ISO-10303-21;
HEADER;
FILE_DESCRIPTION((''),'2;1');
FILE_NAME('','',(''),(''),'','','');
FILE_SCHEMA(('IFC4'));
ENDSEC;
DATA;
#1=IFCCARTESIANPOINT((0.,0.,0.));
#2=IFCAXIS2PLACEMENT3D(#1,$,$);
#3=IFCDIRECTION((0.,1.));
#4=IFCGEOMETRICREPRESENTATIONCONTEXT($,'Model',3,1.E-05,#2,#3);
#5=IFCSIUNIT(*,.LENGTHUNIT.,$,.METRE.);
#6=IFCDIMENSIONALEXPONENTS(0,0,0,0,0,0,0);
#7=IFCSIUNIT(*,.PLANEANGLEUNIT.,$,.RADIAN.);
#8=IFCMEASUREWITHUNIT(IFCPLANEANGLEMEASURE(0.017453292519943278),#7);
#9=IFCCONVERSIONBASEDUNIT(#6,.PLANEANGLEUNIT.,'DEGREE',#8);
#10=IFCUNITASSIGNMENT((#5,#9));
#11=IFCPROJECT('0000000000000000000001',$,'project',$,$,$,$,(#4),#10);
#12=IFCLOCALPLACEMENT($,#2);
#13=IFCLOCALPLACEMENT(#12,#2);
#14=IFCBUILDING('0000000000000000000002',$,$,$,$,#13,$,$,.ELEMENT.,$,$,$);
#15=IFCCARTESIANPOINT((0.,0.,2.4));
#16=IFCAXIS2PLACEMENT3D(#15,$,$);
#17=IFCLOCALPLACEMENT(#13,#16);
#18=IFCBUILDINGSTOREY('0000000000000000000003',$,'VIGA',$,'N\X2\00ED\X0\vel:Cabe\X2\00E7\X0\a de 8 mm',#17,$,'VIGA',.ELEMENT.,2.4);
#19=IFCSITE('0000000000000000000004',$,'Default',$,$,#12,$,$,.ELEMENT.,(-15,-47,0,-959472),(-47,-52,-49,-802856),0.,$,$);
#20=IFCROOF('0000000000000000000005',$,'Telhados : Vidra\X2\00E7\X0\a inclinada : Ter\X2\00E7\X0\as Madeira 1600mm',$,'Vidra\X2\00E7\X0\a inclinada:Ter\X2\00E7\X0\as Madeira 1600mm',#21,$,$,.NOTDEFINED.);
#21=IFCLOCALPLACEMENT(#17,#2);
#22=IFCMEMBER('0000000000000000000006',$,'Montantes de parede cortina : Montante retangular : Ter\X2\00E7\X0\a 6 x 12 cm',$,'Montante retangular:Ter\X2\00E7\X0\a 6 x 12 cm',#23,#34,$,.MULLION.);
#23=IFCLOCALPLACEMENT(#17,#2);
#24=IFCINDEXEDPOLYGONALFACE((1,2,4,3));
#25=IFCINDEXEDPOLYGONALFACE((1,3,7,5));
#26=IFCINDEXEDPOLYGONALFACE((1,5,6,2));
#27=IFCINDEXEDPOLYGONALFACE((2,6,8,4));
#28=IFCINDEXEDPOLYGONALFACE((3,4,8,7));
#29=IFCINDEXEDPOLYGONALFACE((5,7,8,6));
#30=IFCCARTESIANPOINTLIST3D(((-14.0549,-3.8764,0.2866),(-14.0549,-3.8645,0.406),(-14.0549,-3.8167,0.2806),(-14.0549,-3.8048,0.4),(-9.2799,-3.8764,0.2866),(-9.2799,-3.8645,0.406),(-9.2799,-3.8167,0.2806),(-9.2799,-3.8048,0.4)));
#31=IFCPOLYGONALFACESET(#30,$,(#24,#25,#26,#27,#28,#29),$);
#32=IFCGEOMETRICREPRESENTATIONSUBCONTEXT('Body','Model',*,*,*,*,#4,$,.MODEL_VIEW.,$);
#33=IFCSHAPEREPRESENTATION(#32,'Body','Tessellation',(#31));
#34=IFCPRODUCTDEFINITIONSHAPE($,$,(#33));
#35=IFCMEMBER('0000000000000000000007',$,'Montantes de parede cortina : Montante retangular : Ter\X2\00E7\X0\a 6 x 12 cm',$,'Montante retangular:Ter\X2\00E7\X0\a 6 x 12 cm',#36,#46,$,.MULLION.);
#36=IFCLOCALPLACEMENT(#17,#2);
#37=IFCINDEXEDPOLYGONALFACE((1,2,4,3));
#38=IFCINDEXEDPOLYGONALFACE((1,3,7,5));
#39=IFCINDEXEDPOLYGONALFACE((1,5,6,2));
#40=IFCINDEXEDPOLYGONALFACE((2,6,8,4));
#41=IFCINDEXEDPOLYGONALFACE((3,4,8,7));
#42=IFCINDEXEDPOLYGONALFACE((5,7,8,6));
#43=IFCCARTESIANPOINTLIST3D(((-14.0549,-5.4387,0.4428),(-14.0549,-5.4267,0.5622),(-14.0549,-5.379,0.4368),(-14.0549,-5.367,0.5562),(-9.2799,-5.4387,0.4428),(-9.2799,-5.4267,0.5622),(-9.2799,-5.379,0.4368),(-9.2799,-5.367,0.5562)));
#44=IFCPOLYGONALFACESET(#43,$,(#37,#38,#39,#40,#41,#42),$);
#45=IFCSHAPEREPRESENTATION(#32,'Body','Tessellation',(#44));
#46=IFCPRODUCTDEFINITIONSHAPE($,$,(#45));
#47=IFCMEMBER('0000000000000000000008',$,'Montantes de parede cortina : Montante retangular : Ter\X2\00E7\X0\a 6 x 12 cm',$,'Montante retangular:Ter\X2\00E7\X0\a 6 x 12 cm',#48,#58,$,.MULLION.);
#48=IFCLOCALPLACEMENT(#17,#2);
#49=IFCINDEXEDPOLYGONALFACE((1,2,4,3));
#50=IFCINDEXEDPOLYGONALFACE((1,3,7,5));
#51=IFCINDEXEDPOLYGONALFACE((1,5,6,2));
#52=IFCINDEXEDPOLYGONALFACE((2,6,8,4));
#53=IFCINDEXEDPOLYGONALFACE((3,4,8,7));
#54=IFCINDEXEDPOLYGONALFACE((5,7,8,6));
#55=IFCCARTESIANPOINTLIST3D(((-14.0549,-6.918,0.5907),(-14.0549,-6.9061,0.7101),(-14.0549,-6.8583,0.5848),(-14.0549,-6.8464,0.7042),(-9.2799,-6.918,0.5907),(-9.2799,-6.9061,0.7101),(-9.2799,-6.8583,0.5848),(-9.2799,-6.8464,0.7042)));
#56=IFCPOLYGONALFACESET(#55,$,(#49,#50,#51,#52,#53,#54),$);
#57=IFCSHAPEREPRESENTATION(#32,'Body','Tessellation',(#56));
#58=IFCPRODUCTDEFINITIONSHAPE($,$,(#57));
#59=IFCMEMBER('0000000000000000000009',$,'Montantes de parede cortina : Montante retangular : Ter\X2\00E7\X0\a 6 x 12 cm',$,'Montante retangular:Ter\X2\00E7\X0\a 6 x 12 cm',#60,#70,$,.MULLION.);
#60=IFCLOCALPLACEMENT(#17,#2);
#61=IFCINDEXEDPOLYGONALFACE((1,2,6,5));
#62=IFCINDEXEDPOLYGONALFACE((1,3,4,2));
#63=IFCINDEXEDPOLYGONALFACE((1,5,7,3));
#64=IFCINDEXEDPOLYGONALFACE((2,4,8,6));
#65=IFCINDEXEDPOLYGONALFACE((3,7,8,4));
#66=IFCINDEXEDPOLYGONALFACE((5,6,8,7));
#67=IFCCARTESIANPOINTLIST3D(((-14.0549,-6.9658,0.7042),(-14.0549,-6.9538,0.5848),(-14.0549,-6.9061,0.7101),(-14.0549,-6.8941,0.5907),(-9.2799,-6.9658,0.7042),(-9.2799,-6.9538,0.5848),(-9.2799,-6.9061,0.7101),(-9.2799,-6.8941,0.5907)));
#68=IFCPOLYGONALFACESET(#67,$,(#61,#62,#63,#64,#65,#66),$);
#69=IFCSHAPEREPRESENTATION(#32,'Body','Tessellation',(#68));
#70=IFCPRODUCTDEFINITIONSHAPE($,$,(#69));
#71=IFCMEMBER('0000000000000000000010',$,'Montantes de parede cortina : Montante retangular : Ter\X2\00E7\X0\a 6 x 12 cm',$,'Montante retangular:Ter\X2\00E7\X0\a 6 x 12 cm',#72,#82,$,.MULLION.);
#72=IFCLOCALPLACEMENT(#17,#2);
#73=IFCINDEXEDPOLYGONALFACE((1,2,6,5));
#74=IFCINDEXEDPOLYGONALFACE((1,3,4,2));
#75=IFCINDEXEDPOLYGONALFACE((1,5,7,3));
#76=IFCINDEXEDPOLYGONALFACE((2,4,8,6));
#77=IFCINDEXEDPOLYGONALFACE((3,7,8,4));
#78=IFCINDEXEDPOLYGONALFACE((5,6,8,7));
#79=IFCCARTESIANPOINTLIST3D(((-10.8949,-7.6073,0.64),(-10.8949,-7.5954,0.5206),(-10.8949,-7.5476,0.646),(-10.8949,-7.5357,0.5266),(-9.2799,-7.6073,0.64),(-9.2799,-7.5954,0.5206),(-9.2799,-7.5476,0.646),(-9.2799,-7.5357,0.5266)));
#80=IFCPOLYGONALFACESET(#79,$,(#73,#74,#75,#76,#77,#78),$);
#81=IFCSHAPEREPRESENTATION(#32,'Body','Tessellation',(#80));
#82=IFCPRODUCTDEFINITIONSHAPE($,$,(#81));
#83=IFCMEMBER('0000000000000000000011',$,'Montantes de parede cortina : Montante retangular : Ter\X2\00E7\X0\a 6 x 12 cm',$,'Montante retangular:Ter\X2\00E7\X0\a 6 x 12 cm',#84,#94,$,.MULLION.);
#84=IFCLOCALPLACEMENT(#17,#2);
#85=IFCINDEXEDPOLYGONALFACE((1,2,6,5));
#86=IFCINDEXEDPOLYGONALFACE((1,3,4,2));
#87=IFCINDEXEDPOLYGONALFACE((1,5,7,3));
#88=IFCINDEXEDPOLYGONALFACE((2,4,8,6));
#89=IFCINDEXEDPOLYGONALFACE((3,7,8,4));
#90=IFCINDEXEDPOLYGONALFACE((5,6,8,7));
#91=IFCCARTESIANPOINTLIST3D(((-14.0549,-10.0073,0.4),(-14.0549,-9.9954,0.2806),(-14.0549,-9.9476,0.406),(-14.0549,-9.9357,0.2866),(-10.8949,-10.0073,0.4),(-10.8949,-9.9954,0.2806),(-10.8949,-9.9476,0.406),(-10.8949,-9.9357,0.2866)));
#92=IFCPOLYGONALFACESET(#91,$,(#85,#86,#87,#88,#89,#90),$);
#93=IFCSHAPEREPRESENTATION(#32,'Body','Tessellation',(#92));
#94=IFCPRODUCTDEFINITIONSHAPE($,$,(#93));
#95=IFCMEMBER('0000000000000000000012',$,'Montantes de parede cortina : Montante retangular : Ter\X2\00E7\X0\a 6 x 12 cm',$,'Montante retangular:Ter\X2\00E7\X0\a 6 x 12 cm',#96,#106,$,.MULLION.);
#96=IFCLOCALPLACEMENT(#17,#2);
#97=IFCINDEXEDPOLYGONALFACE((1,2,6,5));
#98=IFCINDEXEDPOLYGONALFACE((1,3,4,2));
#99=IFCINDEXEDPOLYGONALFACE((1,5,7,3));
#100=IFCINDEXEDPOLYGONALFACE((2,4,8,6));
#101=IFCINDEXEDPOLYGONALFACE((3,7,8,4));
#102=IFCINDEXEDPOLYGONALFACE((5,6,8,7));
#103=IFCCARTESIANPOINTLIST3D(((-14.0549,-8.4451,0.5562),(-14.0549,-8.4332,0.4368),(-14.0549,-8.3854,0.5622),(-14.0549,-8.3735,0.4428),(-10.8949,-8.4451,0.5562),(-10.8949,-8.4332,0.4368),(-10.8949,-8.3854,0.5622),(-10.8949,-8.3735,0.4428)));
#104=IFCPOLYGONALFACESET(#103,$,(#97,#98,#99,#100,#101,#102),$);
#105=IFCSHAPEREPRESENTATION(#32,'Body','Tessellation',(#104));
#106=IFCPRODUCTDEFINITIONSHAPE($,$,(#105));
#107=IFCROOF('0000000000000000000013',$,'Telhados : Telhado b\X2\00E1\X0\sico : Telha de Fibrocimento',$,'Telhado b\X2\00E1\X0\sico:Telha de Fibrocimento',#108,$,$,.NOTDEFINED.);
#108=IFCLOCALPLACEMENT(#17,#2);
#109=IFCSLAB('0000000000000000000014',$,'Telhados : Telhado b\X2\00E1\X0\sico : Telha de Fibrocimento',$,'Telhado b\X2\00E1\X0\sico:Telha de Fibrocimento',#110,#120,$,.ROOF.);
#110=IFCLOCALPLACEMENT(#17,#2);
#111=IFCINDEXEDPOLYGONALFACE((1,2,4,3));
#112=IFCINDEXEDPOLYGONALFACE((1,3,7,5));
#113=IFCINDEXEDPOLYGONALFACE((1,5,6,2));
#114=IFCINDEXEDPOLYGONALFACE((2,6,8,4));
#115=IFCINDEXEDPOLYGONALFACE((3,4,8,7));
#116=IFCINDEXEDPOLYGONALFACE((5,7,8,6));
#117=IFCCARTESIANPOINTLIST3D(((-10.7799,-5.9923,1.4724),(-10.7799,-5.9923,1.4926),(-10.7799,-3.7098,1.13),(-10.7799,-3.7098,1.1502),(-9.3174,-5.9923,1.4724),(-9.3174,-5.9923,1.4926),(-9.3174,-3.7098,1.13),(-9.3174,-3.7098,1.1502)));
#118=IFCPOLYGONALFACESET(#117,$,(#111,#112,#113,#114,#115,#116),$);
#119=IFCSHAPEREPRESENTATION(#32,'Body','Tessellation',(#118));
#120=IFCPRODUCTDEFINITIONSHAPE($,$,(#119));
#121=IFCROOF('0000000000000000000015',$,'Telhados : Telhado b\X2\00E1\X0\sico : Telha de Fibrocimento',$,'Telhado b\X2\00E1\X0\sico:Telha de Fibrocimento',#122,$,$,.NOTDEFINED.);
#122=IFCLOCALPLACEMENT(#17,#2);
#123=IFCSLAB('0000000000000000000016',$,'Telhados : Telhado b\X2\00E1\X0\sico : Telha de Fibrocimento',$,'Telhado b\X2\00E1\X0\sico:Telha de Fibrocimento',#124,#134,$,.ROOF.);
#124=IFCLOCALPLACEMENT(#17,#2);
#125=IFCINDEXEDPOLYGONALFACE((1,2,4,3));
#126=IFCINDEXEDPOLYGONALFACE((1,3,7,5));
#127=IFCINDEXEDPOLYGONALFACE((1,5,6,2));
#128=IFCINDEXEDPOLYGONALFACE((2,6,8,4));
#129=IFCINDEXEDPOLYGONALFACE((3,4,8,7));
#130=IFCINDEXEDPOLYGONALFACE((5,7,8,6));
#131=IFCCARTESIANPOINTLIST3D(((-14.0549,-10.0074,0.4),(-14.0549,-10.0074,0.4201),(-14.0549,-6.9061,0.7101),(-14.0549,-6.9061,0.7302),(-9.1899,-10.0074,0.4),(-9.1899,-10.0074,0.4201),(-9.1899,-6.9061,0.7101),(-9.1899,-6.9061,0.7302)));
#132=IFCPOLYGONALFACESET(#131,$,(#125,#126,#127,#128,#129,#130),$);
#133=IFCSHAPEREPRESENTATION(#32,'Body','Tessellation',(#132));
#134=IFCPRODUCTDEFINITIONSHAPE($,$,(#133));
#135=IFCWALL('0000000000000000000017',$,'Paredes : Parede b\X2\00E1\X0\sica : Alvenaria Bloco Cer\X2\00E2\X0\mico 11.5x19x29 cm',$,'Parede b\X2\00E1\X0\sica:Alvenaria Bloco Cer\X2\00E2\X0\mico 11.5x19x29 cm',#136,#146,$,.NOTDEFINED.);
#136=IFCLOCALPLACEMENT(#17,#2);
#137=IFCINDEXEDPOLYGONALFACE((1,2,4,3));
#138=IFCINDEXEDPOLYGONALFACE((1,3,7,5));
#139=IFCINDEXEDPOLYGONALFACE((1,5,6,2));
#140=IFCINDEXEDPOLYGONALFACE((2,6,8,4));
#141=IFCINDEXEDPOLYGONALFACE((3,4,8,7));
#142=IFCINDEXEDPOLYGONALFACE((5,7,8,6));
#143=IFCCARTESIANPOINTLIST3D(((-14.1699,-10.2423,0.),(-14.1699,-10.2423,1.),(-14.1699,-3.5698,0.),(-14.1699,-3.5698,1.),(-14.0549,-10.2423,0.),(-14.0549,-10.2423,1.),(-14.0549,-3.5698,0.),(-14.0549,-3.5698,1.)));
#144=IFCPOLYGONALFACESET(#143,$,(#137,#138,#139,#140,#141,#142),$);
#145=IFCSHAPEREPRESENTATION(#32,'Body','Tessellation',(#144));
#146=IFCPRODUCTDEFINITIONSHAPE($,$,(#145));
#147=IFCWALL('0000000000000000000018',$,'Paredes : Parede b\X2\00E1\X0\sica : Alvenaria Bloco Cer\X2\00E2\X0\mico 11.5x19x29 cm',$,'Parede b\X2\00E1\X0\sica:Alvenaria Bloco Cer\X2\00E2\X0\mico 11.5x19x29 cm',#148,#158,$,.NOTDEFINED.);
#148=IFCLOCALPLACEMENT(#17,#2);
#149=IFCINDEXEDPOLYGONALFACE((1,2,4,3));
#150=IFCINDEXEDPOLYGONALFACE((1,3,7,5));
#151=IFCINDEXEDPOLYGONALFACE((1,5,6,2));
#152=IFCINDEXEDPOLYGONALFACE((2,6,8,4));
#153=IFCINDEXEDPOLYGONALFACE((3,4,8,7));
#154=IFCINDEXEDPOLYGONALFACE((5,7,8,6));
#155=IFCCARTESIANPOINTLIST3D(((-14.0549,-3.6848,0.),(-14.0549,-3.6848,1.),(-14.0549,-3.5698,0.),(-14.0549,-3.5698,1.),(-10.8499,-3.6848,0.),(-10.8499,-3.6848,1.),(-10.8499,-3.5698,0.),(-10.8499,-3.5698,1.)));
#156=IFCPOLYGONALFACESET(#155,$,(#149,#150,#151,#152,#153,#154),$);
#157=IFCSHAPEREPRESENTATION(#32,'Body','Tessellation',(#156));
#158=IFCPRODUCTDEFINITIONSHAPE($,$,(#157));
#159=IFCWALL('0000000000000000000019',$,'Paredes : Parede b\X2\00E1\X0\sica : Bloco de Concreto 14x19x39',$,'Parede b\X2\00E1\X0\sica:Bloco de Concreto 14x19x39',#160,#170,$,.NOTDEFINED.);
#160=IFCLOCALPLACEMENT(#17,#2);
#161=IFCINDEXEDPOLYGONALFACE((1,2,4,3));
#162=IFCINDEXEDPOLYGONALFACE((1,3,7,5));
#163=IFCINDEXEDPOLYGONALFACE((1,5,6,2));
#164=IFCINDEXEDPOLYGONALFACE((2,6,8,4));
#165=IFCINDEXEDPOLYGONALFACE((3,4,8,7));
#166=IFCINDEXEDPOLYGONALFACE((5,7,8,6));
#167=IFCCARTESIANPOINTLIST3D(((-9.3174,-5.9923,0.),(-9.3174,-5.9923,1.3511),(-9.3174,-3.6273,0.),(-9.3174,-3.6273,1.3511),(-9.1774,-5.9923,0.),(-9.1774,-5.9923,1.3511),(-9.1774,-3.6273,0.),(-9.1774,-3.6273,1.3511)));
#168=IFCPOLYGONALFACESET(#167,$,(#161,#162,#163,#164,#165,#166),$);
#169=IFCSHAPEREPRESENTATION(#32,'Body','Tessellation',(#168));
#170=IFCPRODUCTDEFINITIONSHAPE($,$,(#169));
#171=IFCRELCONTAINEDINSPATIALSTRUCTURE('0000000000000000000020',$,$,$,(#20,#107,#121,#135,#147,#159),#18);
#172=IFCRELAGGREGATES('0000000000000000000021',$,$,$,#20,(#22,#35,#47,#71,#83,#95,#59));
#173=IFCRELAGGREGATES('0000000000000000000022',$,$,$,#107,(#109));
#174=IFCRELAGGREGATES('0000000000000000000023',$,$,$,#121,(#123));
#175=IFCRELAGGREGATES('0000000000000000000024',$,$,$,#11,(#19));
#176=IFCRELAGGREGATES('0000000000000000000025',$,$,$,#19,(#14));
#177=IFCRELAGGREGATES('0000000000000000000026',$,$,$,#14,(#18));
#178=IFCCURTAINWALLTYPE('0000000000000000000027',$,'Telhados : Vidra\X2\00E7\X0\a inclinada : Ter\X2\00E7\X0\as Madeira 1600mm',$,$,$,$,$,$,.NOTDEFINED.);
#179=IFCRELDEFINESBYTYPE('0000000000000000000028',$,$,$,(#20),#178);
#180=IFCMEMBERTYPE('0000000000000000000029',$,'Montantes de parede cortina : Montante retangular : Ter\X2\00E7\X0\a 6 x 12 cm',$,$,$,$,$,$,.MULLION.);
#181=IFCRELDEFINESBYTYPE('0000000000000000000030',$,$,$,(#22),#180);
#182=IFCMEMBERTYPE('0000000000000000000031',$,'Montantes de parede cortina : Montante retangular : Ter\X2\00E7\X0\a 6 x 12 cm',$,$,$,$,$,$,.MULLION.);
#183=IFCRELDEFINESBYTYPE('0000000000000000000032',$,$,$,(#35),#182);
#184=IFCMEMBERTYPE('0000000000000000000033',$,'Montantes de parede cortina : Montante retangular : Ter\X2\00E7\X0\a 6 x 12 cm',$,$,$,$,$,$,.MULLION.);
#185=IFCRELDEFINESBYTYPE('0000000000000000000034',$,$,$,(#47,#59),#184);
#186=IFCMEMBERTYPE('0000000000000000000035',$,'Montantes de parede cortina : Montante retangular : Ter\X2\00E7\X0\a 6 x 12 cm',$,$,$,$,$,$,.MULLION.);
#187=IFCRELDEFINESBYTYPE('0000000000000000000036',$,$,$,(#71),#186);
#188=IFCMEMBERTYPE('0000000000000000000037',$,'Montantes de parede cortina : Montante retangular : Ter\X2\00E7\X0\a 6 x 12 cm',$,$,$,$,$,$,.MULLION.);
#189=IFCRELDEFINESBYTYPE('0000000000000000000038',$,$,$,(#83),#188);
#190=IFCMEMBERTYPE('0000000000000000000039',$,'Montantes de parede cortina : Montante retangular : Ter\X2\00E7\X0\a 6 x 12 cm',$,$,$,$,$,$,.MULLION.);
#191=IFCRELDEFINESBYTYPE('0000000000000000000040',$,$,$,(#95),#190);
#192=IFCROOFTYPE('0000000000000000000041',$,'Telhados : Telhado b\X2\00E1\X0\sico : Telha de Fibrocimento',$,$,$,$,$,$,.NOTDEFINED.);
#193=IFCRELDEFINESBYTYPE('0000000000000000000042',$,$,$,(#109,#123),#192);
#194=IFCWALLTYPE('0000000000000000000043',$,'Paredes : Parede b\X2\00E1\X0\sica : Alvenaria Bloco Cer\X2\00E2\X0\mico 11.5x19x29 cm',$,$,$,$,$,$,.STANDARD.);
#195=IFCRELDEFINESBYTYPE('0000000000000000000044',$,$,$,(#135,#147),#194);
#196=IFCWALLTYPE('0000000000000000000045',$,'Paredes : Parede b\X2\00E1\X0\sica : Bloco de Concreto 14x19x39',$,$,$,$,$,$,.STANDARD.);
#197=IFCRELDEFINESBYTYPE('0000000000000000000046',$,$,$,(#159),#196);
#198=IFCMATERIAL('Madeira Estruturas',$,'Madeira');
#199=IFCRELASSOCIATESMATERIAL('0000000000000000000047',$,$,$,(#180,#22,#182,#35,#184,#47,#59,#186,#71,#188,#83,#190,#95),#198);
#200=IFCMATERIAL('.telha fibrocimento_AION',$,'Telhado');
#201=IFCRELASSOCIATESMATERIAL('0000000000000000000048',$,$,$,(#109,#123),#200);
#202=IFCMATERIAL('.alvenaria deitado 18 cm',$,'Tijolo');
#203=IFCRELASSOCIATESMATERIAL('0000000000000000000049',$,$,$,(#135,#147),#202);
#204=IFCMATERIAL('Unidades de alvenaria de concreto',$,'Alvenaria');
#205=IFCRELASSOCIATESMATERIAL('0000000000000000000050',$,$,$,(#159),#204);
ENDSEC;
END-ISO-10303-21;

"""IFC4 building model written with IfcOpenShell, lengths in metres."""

from ifc_helpers import new_model, entity, si_unit, converted_unit, direction, frame, origin, place, context, subcontext, project, spatial, indexed_curve, outline, extrude, source, transform, mapped, material, type_object, type_shapes, element, aggregate, save


model = new_model("IFC4")

# Units and contexts
model_context = context("Model", 3, precision=1e-05, world=origin(), true_north=direction((0.0, 1.0)))
body_context = subcontext(model_context, "Body", "Model", "MODEL_VIEW")
ifc_project = project(units=[si_unit("LENGTHUNIT", "METRE"), converted_unit("PLANEANGLEUNIT", "DEGREE", entity("IfcPlaneAngleMeasure", 0.017453292519943278), si_unit("PLANEANGLEUNIT", "RADIAN"), dimensions=[0, 0, 0, 0, 0, 0, 0])], contexts=[model_context])

# Site, building, storey
site_placement = place(None, origin())
site = spatial("IfcSite", under=ifc_project, at=site_placement, Name="Default", CompositionType="ELEMENT", RefLatitude=(-15, -47, 0, -959472), RefLongitude=(-47, -52, -49, -802856), RefElevation=0.0)
building_placement = place(site_placement, origin())
building = spatial("IfcBuilding", under=site, at=building_placement, CompositionType="ELEMENT")
storey_placement = place(building_placement, frame((0.0, 0.0, 2.4)))
storey = spatial("IfcBuildingStorey", under=building, at=storey_placement, Name="VIGA", ObjectType="Nível:Cabeça de 8 mm", LongName="VIGA", CompositionType="ELEMENT", Elevation=2.4)

# Roof, members
curtain_wall_type = type_object("IfcCurtainWallType", Name="Telhados : Vidraça inclinada : Terças Madeira 1600mm", PredefinedType="NOTDEFINED")
roof_1_placement = place(storey_placement, frame((0.0, 0.0, -2.4)))
roof_1 = element("IfcRoof", 1, at=roof_1_placement, inside=storey, type_object=curtain_wall_type, Name="Telhados : Vidraça inclinada : Terças Madeira 1600mm", ObjectType="Vidraça inclinada:Terças Madeira 1600mm", PredefinedType="NOTDEFINED")
ifc_material_1 = material(Name="Madeira Estruturas", Category="Madeira")
member_type_1 = type_object("IfcMemberType", Name="Montantes de parede cortina : Montante retangular : Terça 6 x 12 cm", PredefinedType="MULLION", material=ifc_material_1)
shared_shape_1 = source(origin(), body_context, "Body", "SweptSolid", [
    extrude(outline(indexed_curve([(-0.03, -0.06), (0.03, -0.06), (0.03, 0.06), (-0.03, 0.06), (-0.03, -0.06)], self_intersect=False)), frame((-0.03, 0.06, -4.775), z_axis=(0.0, 0.0, 1.0), x_axis=(-1.0, 0.0, 0.0)), (0.0, 0.0, 1.0), 4.775),
])
type_shapes(member_type_1, [shared_shape_1])
member_1_placement = place(roof_1_placement, frame((-14.0549, -3.8048, 2.8), z_axis=(-1.0, 0.0, 0.0), x_axis=(0.0, 0.995037, -0.099504)))
member_1 = element("IfcMember", 2, at=member_1_placement, type_object=member_type_1, material=ifc_material_1, Name="Montantes de parede cortina : Montante retangular : Terça 6 x 12 cm", ObjectType="Montante retangular:Terça 6 x 12 cm", PredefinedType="MULLION", context=body_context, shape_type="MappedRepresentation", body=[
    mapped(shared_shape_1, transform((0.0, 0.0, 0.0), scale=1.0)),
])
member_type_2 = type_object("IfcMemberType", Name="Montantes de parede cortina : Montante retangular : Terça 6 x 12 cm", PredefinedType="MULLION", material=ifc_material_1)
shared_shape_2 = source(origin(), body_context, "Body", "SweptSolid", [
    extrude(outline(indexed_curve([(-0.03, -0.06), (0.03, -0.06), (0.03, 0.06), (-0.03, 0.06), (-0.03, -0.06)], self_intersect=False)), frame((0.0, 0.06, -4.775), z_axis=(0.0, 0.0, 1.0), x_axis=(-1.0, 0.0, 0.0)), (0.0, 0.0, 1.0), 4.775),
])
type_shapes(member_type_2, [shared_shape_2])
member_2_placement = place(roof_1_placement, frame((-9.2799, -5.3969, 2.9592), z_axis=(1.0, 0.0, 0.0), x_axis=(0.0, -0.995037, 0.099504)))
member_2 = element("IfcMember", 3, at=member_2_placement, type_object=member_type_2, material=ifc_material_1, Name="Montantes de parede cortina : Montante retangular : Terça 6 x 12 cm", ObjectType="Montante retangular:Terça 6 x 12 cm", PredefinedType="MULLION", context=body_context, shape_type="MappedRepresentation", body=[
    mapped(shared_shape_2, transform((0.0, 0.0, 0.0), scale=1.0)),
])
member_type_3 = type_object("IfcMemberType", Name="Montantes de parede cortina : Montante retangular : Terça 6 x 12 cm", PredefinedType="MULLION", material=ifc_material_1)
shared_shape_3 = source(origin(), body_context, "Body", "SweptSolid", [
    extrude(outline(indexed_curve([(-0.03, -0.06), (0.03, -0.06), (0.03, 0.06), (-0.03, 0.06), (-0.03, -0.06)], self_intersect=False)), frame((-0.03, 0.06, -4.775), z_axis=(0.0, 0.0, 1.0), x_axis=(-1.0, 0.0, 0.0)), (0.0, 0.0, 1.0), 4.775),
])
type_shapes(member_type_3, [shared_shape_3])
member_3_placement = place(roof_1_placement, frame((-9.2799, -6.9061, 3.1101), z_axis=(1.0, 0.0, 0.0), x_axis=(0.0, -0.995037, 0.099504)))
member_3 = element("IfcMember", 4, at=member_3_placement, type_object=member_type_3, material=ifc_material_1, Name="Montantes de parede cortina : Montante retangular : Terça 6 x 12 cm", ObjectType="Montante retangular:Terça 6 x 12 cm", PredefinedType="MULLION", context=body_context, shape_type="MappedRepresentation", body=[
    mapped(shared_shape_3, transform((0.0, 0.0, 0.0), scale=1.0)),
])
member_4_placement = place(roof_1_placement, frame((-14.0549, -6.9061, 3.1101), z_axis=(-1.0, 0.0, 0.0), x_axis=(0.0, 0.995037, 0.099504)))
member_4 = element("IfcMember", 5, at=member_4_placement, type_object=member_type_3, material=ifc_material_1, Name="Montantes de parede cortina : Montante retangular : Terça 6 x 12 cm", ObjectType="Montante retangular:Terça 6 x 12 cm", PredefinedType="MULLION", context=body_context, shape_type="MappedRepresentation", body=[
    mapped(shared_shape_3, transform((0.0, 0.0, 0.0), scale=1.0)),
])
member_type_4 = type_object("IfcMemberType", Name="Montantes de parede cortina : Montante retangular : Terça 6 x 12 cm", PredefinedType="MULLION", material=ifc_material_1)
shared_shape_4 = source(origin(), body_context, "Body", "SweptSolid", [
    extrude(outline(indexed_curve([(-0.03, -0.06), (0.03, -0.06), (0.03, 0.06), (-0.03, 0.06), (-0.03, -0.06)], self_intersect=False)), frame((-0.03, 0.06, -1.615), z_axis=(0.0, 0.0, 1.0), x_axis=(-1.0, 0.0, 0.0)), (0.0, 0.0, 1.0), 1.615),
])
type_shapes(member_type_4, [shared_shape_4])
member_5_placement = place(roof_1_placement, frame((-9.2799, -7.6073, 3.04), z_axis=(1.0, 0.0, 0.0), x_axis=(0.0, -0.995037, -0.099504)))
member_5 = element("IfcMember", 6, at=member_5_placement, type_object=member_type_4, material=ifc_material_1, Name="Montantes de parede cortina : Montante retangular : Terça 6 x 12 cm", ObjectType="Montante retangular:Terça 6 x 12 cm", PredefinedType="MULLION", context=body_context, shape_type="MappedRepresentation", body=[
    mapped(shared_shape_4, transform((0.0, 0.0, 0.0), scale=1.0)),
])
member_type_5 = type_object("IfcMemberType", Name="Montantes de parede cortina : Montante retangular : Terça 6 x 12 cm", PredefinedType="MULLION", material=ifc_material_1)
shared_shape_5 = source(origin(), body_context, "Body", "SweptSolid", [
    extrude(outline(indexed_curve([(-0.03, -0.06), (0.03, -0.06), (0.03, 0.06), (-0.03, 0.06), (-0.03, -0.06)], self_intersect=False)), frame((-0.03, 0.06, -3.16), z_axis=(0.0, 0.0, 1.0), x_axis=(-1.0, 0.0, 0.0)), (0.0, 0.0, 1.0), 3.16),
])
type_shapes(member_type_5, [shared_shape_5])
member_6_placement = place(roof_1_placement, frame((-10.8949, -10.0073, 2.8), z_axis=(1.0, 0.0, 0.0), x_axis=(0.0, -0.995037, -0.099504)))
member_6 = element("IfcMember", 7, at=member_6_placement, type_object=member_type_5, material=ifc_material_1, Name="Montantes de parede cortina : Montante retangular : Terça 6 x 12 cm", ObjectType="Montante retangular:Terça 6 x 12 cm", PredefinedType="MULLION", context=body_context, shape_type="MappedRepresentation", body=[
    mapped(shared_shape_5, transform((0.0, 0.0, 0.0), scale=1.0)),
])
member_type_6 = type_object("IfcMemberType", Name="Montantes de parede cortina : Montante retangular : Terça 6 x 12 cm", PredefinedType="MULLION", material=ifc_material_1)
shared_shape_6 = source(origin(), body_context, "Body", "SweptSolid", [
    extrude(outline(indexed_curve([(-0.03, -0.06), (0.03, -0.06), (0.03, 0.06), (-0.03, 0.06), (-0.03, -0.06)], self_intersect=False)), frame((0.0, 0.06, -3.16), z_axis=(0.0, 0.0, 1.0), x_axis=(-1.0, 0.0, 0.0)), (0.0, 0.0, 1.0), 3.16),
])
type_shapes(member_type_6, [shared_shape_6])
member_7_placement = place(roof_1_placement, frame((-14.0549, -8.4152, 2.9592), z_axis=(-1.0, 0.0, 0.0), x_axis=(0.0, 0.995037, 0.099504)))
member_7 = element("IfcMember", 8, at=member_7_placement, type_object=member_type_6, material=ifc_material_1, Name="Montantes de parede cortina : Montante retangular : Terça 6 x 12 cm", ObjectType="Montante retangular:Terça 6 x 12 cm", PredefinedType="MULLION", context=body_context, shape_type="MappedRepresentation", body=[
    mapped(shared_shape_6, transform((0.0, 0.0, 0.0), scale=1.0)),
])
aggregate(roof_1, [member_1, member_2, member_3, member_5, member_6, member_7, member_4])

# Roof, slab
roof_2_placement = place(storey_placement, frame((-10.7799, -5.9923, 1.13)))
roof_2 = element("IfcRoof", 9, at=roof_2_placement, inside=storey, Name="Telhados : Telhado básico : Telha de Fibrocimento", ObjectType="Telhado básico:Telha de Fibrocimento", PredefinedType="NOTDEFINED")
ifc_material_2 = material(Name=".telha fibrocimento_AION", Category="Telhado")
roof_type = type_object("IfcRoofType", Name="Telhados : Telhado básico : Telha de Fibrocimento", PredefinedType="NOTDEFINED")
slab_1_placement = place(roof_2_placement, origin())
slab_1 = element("IfcSlab", 10, at=slab_1_placement, type_object=roof_type, material=ifc_material_2, Name="Telhados : Telhado básico : Telha de Fibrocimento", ObjectType="Telhado básico:Telha de Fibrocimento", PredefinedType="ROOF", context=body_context, shape_type="SweptSolid", body=[
    extrude(outline(indexed_curve([(0.7313, 1.154), (-0.7313, 1.154), (-0.7313, -1.154), (0.7313, -1.154), (0.7313, 1.154)], self_intersect=False)), frame((0.7313, 1.1413, 0.1712), z_axis=(0.0, 0.14834, 0.988936), x_axis=(1.0, 0.0, 0.0)), (0.0, -0.14834, 0.988936), 0.0202),
])
aggregate(roof_2, [slab_1])

# Roof, slab
roof_3_placement = place(storey_placement, frame((-14.0549, -10.0074, 0.4)))
roof_3 = element("IfcRoof", 11, at=roof_3_placement, inside=storey, Name="Telhados : Telhado básico : Telha de Fibrocimento", ObjectType="Telhado básico:Telha de Fibrocimento", PredefinedType="NOTDEFINED")
slab_2_placement = place(roof_3_placement, origin())
slab_2 = element("IfcSlab", 12, at=slab_2_placement, type_object=roof_type, material=ifc_material_2, Name="Telhados : Telhado básico : Telha de Fibrocimento", ObjectType="Telhado básico:Telha de Fibrocimento", PredefinedType="ROOF", context=body_context, shape_type="SweptSolid", body=[
    extrude(outline(indexed_curve([(2.4325, -1.5584), (2.4325, 1.5584), (-2.4325, 1.5584), (-2.4325, -1.5584), (2.4325, -1.5584)], self_intersect=False)), frame((2.4325, 1.5506, 0.1551), z_axis=(0.0, -0.099504, 0.995037), x_axis=(1.0, 0.0, 0.0)), (0.0, 0.099504, 0.995037), 0.0201),
])
aggregate(roof_3, [slab_2])

# Walls
ifc_material_3 = material(Name=".alvenaria deitado 18 cm", Category="Tijolo")
wall_type_1 = type_object("IfcWallType", Name="Paredes : Parede básica : Alvenaria Bloco Cerâmico 11.5x19x29 cm", PredefinedType="STANDARD")
wall_1_placement = place(storey_placement, frame((-14.1124, -3.5698, 0.0), z_axis=(0.0, 0.0, 1.0), x_axis=(0.0, -1.0, 0.0)))
element("IfcWall", 13, at=wall_1_placement, inside=storey, type_object=wall_type_1, material=ifc_material_3, Name="Paredes : Parede básica : Alvenaria Bloco Cerâmico 11.5x19x29 cm", ObjectType="Parede básica:Alvenaria Bloco Cerâmico 11.5x19x29 cm", PredefinedType="NOTDEFINED", context=body_context, shape_type="SweptSolid", body=[
    extrude(outline(indexed_curve([(6.6725, 0.0575), (0.0, 0.0575), (0.0, -0.0575), (6.6725, -0.0575), (6.6725, 0.0575)], self_intersect=False)), origin(), (0.0, 0.0, 1.0), 1.0),
])
wall_2_placement = place(storey_placement, frame((-14.0549, -3.6273, 0.0)))
element("IfcWall", 14, at=wall_2_placement, inside=storey, type_object=wall_type_1, material=ifc_material_3, Name="Paredes : Parede básica : Alvenaria Bloco Cerâmico 11.5x19x29 cm", ObjectType="Parede básica:Alvenaria Bloco Cerâmico 11.5x19x29 cm", PredefinedType="NOTDEFINED", context=body_context, shape_type="SweptSolid", body=[
    extrude(outline(indexed_curve([(3.205, 0.0575), (0.0, 0.0575), (0.0, -0.0575), (3.205, -0.0575), (3.205, 0.0575)], self_intersect=False)), origin(), (0.0, 0.0, 1.0), 1.0),
])
ifc_material_4 = material(Name="Unidades de alvenaria de concreto", Category="Alvenaria")
wall_type_2 = type_object("IfcWallType", Name="Paredes : Parede básica : Bloco de Concreto 14x19x39", PredefinedType="STANDARD")
wall_3_placement = place(storey_placement, frame((-9.2474, -3.6273, 0.0), z_axis=(0.0, 0.0, 1.0), x_axis=(0.0, -1.0, 0.0)))
element("IfcWall", 15, at=wall_3_placement, inside=storey, type_object=wall_type_2, material=ifc_material_4, Name="Paredes : Parede básica : Bloco de Concreto 14x19x39", ObjectType="Parede básica:Bloco de Concreto 14x19x39", PredefinedType="NOTDEFINED", context=body_context, shape_type="SweptSolid", body=[
    extrude(outline(indexed_curve([(2.365, 0.07), (0.0, 0.07), (0.0, -0.07), (2.365, -0.07), (2.365, 0.07)], self_intersect=False)), origin(), (0.0, 0.0, 1.0), 1.3511),
])

save(model, "model.ifc")
